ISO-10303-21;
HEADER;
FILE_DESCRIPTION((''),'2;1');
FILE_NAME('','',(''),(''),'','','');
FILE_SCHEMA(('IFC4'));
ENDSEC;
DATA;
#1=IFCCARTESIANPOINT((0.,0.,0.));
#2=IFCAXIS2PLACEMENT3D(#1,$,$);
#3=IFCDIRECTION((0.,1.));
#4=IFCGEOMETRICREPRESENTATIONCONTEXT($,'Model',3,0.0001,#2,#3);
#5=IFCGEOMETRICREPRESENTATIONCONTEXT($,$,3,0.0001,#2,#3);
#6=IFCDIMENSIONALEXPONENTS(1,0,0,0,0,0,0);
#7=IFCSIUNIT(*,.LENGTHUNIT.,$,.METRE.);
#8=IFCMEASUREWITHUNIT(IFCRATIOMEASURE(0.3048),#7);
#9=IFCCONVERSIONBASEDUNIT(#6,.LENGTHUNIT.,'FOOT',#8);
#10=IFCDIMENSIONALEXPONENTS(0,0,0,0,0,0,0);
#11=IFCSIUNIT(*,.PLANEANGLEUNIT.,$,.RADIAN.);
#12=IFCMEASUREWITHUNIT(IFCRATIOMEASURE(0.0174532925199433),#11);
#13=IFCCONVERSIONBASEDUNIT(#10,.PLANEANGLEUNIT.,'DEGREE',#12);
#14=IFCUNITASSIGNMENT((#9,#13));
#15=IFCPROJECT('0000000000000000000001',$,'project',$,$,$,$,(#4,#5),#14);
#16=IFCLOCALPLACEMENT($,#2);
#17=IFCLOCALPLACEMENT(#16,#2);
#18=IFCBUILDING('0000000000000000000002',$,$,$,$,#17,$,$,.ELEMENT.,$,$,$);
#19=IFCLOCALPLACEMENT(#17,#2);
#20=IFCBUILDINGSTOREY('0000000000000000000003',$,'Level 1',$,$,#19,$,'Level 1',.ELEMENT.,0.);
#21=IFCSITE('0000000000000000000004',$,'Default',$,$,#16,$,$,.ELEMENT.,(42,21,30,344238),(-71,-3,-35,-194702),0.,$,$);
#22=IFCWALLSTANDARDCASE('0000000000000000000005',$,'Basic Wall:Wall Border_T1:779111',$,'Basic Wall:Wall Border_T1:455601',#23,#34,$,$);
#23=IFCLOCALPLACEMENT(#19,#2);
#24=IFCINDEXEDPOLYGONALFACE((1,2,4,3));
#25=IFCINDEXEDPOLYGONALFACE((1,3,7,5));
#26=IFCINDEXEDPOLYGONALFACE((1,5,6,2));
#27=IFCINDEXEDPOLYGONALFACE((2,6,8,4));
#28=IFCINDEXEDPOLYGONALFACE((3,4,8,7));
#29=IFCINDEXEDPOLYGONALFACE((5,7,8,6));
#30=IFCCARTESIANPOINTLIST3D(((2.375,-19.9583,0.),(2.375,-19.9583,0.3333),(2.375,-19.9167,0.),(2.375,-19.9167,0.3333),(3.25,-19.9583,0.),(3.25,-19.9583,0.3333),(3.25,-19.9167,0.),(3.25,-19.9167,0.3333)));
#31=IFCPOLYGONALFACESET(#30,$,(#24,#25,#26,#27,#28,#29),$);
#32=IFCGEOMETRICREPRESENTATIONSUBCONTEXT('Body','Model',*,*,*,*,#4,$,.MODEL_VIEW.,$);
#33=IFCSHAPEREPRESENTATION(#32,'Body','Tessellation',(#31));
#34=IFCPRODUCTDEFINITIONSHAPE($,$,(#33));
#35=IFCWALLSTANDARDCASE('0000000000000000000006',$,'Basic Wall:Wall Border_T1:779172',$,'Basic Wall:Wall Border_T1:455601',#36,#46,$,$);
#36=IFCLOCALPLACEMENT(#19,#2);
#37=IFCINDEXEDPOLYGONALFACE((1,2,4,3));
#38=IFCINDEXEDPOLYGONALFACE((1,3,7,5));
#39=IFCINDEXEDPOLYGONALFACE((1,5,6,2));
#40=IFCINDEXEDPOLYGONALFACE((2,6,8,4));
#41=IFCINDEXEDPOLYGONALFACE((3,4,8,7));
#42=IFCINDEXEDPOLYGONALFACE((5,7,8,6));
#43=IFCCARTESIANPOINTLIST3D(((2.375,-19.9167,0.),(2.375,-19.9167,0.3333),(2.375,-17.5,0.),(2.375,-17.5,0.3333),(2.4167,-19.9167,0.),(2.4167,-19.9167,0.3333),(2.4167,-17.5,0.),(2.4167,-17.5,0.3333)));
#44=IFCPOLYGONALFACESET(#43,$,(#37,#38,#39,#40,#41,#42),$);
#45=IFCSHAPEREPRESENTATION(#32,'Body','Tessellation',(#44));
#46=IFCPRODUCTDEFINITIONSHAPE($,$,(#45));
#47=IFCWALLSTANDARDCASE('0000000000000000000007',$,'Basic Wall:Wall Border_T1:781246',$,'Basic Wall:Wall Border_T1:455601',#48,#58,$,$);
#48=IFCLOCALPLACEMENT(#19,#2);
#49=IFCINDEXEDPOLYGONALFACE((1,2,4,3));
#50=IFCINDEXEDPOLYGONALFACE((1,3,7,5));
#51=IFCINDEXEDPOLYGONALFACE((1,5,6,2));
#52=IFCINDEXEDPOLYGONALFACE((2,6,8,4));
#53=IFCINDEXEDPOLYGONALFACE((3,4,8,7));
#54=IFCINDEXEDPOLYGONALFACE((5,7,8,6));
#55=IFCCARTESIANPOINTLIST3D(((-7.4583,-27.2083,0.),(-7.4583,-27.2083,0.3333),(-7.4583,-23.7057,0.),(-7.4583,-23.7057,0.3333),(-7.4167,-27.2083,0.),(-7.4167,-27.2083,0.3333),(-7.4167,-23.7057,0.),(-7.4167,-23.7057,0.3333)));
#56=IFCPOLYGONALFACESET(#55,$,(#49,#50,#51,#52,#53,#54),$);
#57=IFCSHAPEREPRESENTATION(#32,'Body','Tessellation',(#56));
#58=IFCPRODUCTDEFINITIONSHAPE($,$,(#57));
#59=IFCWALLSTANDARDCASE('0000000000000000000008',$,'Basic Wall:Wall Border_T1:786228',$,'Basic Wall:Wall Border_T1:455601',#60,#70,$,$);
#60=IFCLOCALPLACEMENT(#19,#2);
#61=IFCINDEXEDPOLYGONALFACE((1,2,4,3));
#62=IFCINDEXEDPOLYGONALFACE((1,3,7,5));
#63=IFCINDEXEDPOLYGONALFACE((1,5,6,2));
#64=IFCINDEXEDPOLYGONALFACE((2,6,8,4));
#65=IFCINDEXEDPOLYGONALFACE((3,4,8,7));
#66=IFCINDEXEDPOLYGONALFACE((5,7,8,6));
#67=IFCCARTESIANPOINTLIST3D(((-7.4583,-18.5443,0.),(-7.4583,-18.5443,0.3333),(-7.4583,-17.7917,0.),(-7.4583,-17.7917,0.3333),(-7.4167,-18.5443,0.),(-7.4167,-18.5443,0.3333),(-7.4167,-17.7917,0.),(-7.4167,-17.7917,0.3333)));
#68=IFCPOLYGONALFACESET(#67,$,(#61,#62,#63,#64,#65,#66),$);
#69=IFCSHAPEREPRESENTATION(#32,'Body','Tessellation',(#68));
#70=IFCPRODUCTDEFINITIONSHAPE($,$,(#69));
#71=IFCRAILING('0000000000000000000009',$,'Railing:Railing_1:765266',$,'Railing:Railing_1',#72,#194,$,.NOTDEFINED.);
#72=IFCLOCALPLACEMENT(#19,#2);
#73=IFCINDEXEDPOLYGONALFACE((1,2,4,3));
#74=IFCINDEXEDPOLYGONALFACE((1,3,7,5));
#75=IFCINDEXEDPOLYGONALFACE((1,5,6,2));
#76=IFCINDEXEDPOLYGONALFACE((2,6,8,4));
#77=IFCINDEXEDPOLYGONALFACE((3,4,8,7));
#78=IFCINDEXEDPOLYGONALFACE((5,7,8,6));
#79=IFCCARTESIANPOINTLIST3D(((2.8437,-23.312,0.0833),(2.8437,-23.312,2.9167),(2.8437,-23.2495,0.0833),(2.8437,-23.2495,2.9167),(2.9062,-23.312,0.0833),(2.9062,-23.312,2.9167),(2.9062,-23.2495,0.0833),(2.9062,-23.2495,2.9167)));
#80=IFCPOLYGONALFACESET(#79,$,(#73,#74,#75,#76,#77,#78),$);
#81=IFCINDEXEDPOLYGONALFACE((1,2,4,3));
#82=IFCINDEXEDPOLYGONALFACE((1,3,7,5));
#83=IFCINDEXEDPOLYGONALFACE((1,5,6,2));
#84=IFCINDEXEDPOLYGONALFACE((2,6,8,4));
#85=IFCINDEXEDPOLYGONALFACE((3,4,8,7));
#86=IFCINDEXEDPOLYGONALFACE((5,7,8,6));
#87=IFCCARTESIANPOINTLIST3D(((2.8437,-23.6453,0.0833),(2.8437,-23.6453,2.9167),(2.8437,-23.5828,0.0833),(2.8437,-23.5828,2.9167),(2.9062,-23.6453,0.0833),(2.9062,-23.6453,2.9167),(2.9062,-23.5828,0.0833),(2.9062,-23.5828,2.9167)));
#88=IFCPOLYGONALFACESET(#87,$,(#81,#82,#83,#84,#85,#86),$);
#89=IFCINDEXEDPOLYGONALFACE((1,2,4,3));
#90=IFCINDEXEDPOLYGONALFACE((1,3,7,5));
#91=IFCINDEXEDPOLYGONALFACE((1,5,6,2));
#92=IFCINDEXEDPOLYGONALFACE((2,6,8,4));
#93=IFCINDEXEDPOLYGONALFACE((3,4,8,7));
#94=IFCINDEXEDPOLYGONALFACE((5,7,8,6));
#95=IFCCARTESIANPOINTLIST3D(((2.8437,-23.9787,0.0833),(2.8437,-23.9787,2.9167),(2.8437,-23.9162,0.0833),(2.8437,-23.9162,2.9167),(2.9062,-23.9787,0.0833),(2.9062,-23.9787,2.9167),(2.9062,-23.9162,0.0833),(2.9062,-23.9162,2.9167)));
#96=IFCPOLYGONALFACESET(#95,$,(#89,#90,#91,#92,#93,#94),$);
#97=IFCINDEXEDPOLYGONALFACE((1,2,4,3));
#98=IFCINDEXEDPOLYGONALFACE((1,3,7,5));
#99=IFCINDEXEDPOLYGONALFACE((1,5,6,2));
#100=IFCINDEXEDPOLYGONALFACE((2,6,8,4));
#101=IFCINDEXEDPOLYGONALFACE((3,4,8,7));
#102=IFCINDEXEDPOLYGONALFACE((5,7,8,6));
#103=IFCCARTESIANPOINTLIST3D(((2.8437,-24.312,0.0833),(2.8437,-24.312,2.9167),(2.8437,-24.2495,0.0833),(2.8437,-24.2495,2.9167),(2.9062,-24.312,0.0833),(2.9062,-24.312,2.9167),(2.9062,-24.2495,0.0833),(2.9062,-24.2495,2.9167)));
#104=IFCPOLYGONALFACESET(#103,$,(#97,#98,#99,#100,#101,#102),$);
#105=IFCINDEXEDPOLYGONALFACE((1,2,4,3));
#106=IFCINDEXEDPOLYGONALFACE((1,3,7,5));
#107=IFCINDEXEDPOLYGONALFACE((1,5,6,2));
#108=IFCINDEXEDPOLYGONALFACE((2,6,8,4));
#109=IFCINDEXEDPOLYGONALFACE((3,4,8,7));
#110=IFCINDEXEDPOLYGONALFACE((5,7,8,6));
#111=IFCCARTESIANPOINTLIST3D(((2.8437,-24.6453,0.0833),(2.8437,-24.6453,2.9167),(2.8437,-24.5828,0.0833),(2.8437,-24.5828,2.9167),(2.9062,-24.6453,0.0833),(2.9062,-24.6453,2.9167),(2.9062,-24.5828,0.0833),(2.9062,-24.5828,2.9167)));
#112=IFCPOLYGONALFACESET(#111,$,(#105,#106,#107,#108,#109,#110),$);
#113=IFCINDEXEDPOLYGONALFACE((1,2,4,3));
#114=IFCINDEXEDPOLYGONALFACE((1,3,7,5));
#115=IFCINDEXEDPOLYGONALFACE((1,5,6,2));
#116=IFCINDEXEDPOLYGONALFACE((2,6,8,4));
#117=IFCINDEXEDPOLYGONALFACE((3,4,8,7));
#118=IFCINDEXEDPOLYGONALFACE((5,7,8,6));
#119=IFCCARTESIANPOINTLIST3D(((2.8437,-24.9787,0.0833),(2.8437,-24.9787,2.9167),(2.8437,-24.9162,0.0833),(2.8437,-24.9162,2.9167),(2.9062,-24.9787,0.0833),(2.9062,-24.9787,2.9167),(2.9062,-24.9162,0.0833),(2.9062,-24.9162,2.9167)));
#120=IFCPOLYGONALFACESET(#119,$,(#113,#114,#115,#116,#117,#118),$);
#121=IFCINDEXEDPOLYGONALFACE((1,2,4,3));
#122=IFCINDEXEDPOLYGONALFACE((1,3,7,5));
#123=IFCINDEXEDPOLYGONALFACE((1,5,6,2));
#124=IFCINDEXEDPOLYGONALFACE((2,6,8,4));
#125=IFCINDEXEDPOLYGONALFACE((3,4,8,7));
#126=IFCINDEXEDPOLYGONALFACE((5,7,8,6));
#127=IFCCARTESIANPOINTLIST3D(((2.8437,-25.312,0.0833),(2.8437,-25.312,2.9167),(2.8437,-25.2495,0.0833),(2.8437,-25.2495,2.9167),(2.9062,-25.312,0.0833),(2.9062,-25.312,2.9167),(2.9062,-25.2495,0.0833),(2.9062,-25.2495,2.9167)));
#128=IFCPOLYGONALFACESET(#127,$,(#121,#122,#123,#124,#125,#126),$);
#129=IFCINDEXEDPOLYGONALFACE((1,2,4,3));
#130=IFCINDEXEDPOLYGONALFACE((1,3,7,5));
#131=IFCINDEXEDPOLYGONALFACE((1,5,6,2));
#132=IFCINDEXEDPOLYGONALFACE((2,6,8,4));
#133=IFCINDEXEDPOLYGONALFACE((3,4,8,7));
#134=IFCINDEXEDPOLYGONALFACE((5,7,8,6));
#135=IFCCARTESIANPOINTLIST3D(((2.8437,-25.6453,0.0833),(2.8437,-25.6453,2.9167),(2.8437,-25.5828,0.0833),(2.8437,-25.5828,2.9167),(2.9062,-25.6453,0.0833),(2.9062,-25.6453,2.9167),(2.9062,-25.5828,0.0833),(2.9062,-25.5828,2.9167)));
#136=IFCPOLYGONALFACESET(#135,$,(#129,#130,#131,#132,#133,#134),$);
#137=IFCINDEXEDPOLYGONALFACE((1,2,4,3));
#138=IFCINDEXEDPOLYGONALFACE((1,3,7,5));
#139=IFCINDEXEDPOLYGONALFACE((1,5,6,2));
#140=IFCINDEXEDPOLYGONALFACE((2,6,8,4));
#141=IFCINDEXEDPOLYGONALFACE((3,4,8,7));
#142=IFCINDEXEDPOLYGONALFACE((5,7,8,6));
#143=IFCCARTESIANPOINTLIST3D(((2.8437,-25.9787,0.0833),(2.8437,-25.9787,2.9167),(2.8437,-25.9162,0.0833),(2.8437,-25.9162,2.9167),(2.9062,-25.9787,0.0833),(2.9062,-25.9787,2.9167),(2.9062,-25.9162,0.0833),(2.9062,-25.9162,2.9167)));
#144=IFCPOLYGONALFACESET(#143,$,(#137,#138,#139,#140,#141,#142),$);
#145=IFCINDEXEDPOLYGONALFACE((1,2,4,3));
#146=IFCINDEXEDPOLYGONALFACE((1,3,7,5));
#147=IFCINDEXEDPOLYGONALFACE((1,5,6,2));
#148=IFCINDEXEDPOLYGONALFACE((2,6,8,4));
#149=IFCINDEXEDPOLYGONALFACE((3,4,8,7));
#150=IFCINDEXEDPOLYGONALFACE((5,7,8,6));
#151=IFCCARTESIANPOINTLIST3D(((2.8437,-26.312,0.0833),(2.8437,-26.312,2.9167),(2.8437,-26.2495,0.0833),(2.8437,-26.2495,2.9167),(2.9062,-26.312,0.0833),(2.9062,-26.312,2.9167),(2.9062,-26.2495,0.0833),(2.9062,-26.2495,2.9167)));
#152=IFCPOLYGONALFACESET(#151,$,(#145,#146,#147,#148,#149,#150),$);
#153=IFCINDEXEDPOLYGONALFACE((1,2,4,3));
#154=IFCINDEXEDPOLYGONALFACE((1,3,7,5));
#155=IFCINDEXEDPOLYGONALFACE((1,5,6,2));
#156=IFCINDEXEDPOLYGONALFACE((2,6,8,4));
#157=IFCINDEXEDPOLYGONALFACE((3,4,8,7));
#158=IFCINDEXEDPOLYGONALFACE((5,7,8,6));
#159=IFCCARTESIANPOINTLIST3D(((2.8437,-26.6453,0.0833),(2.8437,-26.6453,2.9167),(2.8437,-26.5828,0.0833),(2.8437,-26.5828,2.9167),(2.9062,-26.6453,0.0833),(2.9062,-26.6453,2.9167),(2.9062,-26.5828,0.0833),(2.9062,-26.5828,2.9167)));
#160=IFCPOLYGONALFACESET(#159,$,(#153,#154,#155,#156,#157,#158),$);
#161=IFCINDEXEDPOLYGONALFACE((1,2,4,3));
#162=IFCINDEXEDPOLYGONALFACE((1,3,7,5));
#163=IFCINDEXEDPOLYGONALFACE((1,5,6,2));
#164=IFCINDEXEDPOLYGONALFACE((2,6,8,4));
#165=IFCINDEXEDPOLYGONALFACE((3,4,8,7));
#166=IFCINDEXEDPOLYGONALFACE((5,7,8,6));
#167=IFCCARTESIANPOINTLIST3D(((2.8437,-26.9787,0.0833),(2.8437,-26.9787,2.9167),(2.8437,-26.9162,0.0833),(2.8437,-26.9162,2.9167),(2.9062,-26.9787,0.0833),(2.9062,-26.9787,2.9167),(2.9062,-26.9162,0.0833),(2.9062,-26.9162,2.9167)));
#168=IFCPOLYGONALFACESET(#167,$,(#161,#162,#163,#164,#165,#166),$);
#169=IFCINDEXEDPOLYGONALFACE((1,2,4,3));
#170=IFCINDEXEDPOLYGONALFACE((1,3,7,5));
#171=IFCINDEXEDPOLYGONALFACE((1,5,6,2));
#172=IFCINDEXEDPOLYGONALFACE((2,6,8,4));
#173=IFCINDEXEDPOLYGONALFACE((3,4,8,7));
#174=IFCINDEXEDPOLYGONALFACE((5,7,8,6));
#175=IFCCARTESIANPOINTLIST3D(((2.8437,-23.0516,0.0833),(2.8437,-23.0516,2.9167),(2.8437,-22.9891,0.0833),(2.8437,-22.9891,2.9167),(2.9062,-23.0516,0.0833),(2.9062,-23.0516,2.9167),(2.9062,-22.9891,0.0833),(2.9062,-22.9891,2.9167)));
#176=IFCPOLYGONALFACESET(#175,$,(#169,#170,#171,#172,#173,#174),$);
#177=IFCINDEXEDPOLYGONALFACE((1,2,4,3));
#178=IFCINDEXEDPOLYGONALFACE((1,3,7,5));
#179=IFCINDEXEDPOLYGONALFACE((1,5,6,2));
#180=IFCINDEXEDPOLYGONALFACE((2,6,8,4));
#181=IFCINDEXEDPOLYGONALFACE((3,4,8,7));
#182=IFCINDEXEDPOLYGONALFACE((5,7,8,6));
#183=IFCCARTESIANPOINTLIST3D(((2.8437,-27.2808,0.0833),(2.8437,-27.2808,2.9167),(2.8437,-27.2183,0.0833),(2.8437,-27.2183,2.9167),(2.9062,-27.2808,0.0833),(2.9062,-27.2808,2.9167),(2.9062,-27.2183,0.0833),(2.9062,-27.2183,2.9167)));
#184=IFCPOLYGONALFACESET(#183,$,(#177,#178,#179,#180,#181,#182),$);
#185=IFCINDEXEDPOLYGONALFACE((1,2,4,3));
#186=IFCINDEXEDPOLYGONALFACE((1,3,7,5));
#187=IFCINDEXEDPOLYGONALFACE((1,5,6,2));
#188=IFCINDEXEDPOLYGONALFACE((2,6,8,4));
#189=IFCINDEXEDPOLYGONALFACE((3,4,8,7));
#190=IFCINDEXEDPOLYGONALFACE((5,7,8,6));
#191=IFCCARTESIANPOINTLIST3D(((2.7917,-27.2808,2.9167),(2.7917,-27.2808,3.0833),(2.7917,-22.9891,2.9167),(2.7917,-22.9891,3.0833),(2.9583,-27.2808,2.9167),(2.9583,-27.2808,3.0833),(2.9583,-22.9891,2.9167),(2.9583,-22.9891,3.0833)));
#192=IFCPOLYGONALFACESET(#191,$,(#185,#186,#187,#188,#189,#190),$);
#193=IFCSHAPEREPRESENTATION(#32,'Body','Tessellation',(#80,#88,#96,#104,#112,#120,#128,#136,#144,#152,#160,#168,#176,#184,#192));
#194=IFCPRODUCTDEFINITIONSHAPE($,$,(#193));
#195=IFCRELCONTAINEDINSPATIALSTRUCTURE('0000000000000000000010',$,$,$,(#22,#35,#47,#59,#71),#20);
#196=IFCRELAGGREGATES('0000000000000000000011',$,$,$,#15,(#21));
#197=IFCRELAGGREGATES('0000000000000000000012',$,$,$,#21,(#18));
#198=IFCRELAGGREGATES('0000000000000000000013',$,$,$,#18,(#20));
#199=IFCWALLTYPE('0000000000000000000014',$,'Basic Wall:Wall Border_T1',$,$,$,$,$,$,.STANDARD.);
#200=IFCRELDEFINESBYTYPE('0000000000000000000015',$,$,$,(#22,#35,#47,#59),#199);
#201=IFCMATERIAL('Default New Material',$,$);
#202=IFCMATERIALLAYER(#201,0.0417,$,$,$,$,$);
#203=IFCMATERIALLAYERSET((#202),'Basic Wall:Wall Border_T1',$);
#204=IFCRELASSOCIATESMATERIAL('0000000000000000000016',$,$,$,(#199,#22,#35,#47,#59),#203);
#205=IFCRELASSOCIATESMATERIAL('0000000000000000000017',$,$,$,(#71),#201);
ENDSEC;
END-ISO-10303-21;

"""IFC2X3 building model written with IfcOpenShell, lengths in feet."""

from ifc_helpers import new_model, entity, si_unit, converted_unit, direction, frame, frame_2d, origin, origin_2d_with_axis, place, context, subcontext, project, spatial, rectangle, extrude, material, layer, layer_set, layer_usage, type_object, element, save


model = new_model("IFC2X3")

# Units and contexts
model_context = context("Model", 3, precision=0.0001, world=origin(), true_north=direction((0.0, 1.0)))
context_of_model = context(None, 3, precision=0.0001, world=origin(), true_north=direction((0.0, 1.0)))
body_context = subcontext(model_context, "Body", "Model", "MODEL_VIEW")
ifc_project = project(units=[converted_unit("LENGTHUNIT", "FOOT", entity("IfcRatioMeasure", 0.3048), si_unit("LENGTHUNIT", "METRE"), dimensions=[1, 0, 0, 0, 0, 0, 0]), converted_unit("PLANEANGLEUNIT", "DEGREE", entity("IfcRatioMeasure", 0.0174532925199433), si_unit("PLANEANGLEUNIT", "RADIAN"), dimensions=[0, 0, 0, 0, 0, 0, 0])], contexts=[model_context, context_of_model])

# Site, building, storey
site_placement = place(None, origin())
site = spatial("IfcSite", under=ifc_project, at=site_placement, Name="Default", CompositionType="ELEMENT", RefLatitude=(42, 21, 30, 344238), RefLongitude=(-71, -3, -35, -194702), RefElevation=0.0)
building_placement = place(site_placement, origin())
building = spatial("IfcBuilding", under=site, at=building_placement, CompositionType="ELEMENT")
storey_placement = place(building_placement, origin())
storey = spatial("IfcBuildingStorey", under=building, at=storey_placement, Name="Level 1", LongName="Level 1", CompositionType="ELEMENT", Elevation=0.0)

# Shared definitions
ifc_material = material(Name="Default New Material")

# Walls
ifc_layer_1 = layer(ifc_material, 0.0417)
ifc_layer_set_1 = layer_set([ifc_layer_1], Name="Basic Wall:Wall Border_T1")
wall_type_1 = type_object("IfcWallType", Name="Basic Wall:Wall Border_T1", PredefinedType="STANDARD", material=ifc_layer_set_1)
ifc_layer_usage_1 = layer_usage(ifc_layer_set_1, "AXIS2", "NEGATIVE", 0.0208)
wall_1_placement = place(storey_placement, frame((3.25, -19.9375, 0.0), z_axis=(0.0, 0.0, 1.0), x_axis=(-1.0, 0.0, 0.0)))
element("IfcWallStandardCase", 1, at=wall_1_placement, inside=storey, type_object=wall_type_1, material=ifc_layer_usage_1, Name="Basic Wall:Wall Border_T1:779111", ObjectType="Basic Wall:Wall Border_T1:455601", context=body_context, shape_type="SweptSolid", body=[
    extrude(rectangle(XDim=0.875, YDim=0.0417, at=frame_2d((0.4375, 0.0), x_axis=(-1.0, 0.0))), origin(), (0.0, 0.0, 1.0), 0.3333),
])
ifc_layer_usage_2 = layer_usage(ifc_layer_set_1, "AXIS2", "NEGATIVE", 0.0208)
wall_2_placement = place(storey_placement, frame((2.3958, -19.9167, 0.0), z_axis=(0.0, 0.0, 1.0), x_axis=(0.0, 1.0, 0.0)))
element("IfcWallStandardCase", 2, at=wall_2_placement, inside=storey, type_object=wall_type_1, material=ifc_layer_usage_2, Name="Basic Wall:Wall Border_T1:779172", ObjectType="Basic Wall:Wall Border_T1:455601", context=body_context, shape_type="SweptSolid", body=[
    extrude(rectangle(XDim=2.4167, YDim=0.0417, at=frame_2d((1.2083, 0.0), x_axis=(-1.0, 0.0))), origin(), (0.0, 0.0, 1.0), 0.3333),
])
ifc_layer_usage_3 = layer_usage(ifc_layer_set_1, "AXIS2", "POSITIVE", -0.0208)
wall_3_placement = place(storey_placement, frame((-7.4375, -27.2083, 0.0), z_axis=(0.0, 0.0, 1.0), x_axis=(0.0, 1.0, 0.0)))
element("IfcWallStandardCase", 3, at=wall_3_placement, inside=storey, type_object=wall_type_1, material=ifc_layer_usage_3, Name="Basic Wall:Wall Border_T1:781246", ObjectType="Basic Wall:Wall Border_T1:455601", context=body_context, shape_type="SweptSolid", body=[
    extrude(rectangle(XDim=3.5026, YDim=0.0417, at=frame_2d((1.7513, 0.0), x_axis=(-1.0, 0.0))), origin(), (0.0, 0.0, 1.0), 0.3333),
])
ifc_layer_usage_4 = layer_usage(ifc_layer_set_1, "AXIS2", "POSITIVE", -0.0208)
wall_4_placement = place(storey_placement, frame((-7.4375, -18.5443, 0.0), z_axis=(0.0, 0.0, 1.0), x_axis=(0.0, 1.0, 0.0)))
element("IfcWallStandardCase", 4, at=wall_4_placement, inside=storey, type_object=wall_type_1, material=ifc_layer_usage_4, Name="Basic Wall:Wall Border_T1:786228", ObjectType="Basic Wall:Wall Border_T1:455601", context=body_context, shape_type="SweptSolid", body=[
    extrude(rectangle(XDim=0.7526, YDim=0.0417, at=frame_2d((0.3763, 0.0), x_axis=(-1.0, 0.0))), origin(), (0.0, 0.0, 1.0), 0.3333),
])

# Railing
railing_placement = place(storey_placement, frame((2.7917, -27.2808, 0.0833)))
element("IfcRailing", 5, at=railing_placement, inside=storey, material=ifc_material, Name="Railing:Railing_1:765266", ObjectType="Railing:Railing_1", PredefinedType="NOTDEFINED", context=body_context, shape_type="SweptSolid", body=[
    extrude(rectangle(XDim=0.0625, YDim=0.0625, at=origin_2d_with_axis()), frame((0.0833, 4.0, 0.0), z_axis=(0.0, 0.0, 1.0), x_axis=(0.0, 1.0, 0.0)), (0.0, 0.0, 1.0), 2.8333),
    extrude(rectangle(XDim=0.0625, YDim=0.0625, at=origin_2d_with_axis()), frame((0.0833, 3.6667, 0.0), z_axis=(0.0, 0.0, 1.0), x_axis=(0.0, 1.0, 0.0)), (0.0, 0.0, 1.0), 2.8333),
    extrude(rectangle(XDim=0.0625, YDim=0.0625, at=origin_2d_with_axis()), frame((0.0833, 3.3333, 0.0), z_axis=(0.0, 0.0, 1.0), x_axis=(0.0, 1.0, 0.0)), (0.0, 0.0, 1.0), 2.8333),
    extrude(rectangle(XDim=0.0625, YDim=0.0625, at=origin_2d_with_axis()), frame((0.0833, 3.0, 0.0), z_axis=(0.0, 0.0, 1.0), x_axis=(0.0, 1.0, 0.0)), (0.0, 0.0, 1.0), 2.8333),
    extrude(rectangle(XDim=0.0625, YDim=0.0625, at=origin_2d_with_axis()), frame((0.0833, 2.6667, 0.0), z_axis=(0.0, 0.0, 1.0), x_axis=(0.0, 1.0, 0.0)), (0.0, 0.0, 1.0), 2.8333),
    extrude(rectangle(XDim=0.0625, YDim=0.0625, at=origin_2d_with_axis()), frame((0.0833, 2.3333, 0.0), z_axis=(0.0, 0.0, 1.0), x_axis=(0.0, 1.0, 0.0)), (0.0, 0.0, 1.0), 2.8333),
    extrude(rectangle(XDim=0.0625, YDim=0.0625, at=origin_2d_with_axis()), frame((0.0833, 2.0, 0.0), z_axis=(0.0, 0.0, 1.0), x_axis=(0.0, 1.0, 0.0)), (0.0, 0.0, 1.0), 2.8333),
    extrude(rectangle(XDim=0.0625, YDim=0.0625, at=origin_2d_with_axis()), frame((0.0833, 1.6667, 0.0), z_axis=(0.0, 0.0, 1.0), x_axis=(0.0, 1.0, 0.0)), (0.0, 0.0, 1.0), 2.8333),
    extrude(rectangle(XDim=0.0625, YDim=0.0625, at=origin_2d_with_axis()), frame((0.0833, 1.3333, 0.0), z_axis=(0.0, 0.0, 1.0), x_axis=(0.0, 1.0, 0.0)), (0.0, 0.0, 1.0), 2.8333),
    extrude(rectangle(XDim=0.0625, YDim=0.0625, at=origin_2d_with_axis()), frame((0.0833, 1.0, 0.0), z_axis=(0.0, 0.0, 1.0), x_axis=(0.0, 1.0, 0.0)), (0.0, 0.0, 1.0), 2.8333),
    extrude(rectangle(XDim=0.0625, YDim=0.0625, at=origin_2d_with_axis()), frame((0.0833, 0.6667, 0.0), z_axis=(0.0, 0.0, 1.0), x_axis=(0.0, 1.0, 0.0)), (0.0, 0.0, 1.0), 2.8333),
    extrude(rectangle(XDim=0.0625, YDim=0.0625, at=origin_2d_with_axis()), frame((0.0833, 0.3333, 0.0), z_axis=(0.0, 0.0, 1.0), x_axis=(0.0, 1.0, 0.0)), (0.0, 0.0, 1.0), 2.8333),
    extrude(rectangle(XDim=0.0625, YDim=0.0625, at=origin_2d_with_axis()), frame((0.0833, 4.2604, 0.0), z_axis=(0.0, 0.0, 1.0), x_axis=(0.0, 1.0, 0.0)), (0.0, 0.0, 1.0), 2.8333),
    extrude(rectangle(XDim=0.0625, YDim=0.0625, at=origin_2d_with_axis()), frame((0.0833, 0.0313, 0.0), z_axis=(0.0, 0.0, 1.0), x_axis=(0.0, 1.0, 0.0)), (0.0, 0.0, 1.0), 2.8333),
    extrude(rectangle(XDim=4.2917, YDim=0.1667, at=frame_2d((0.0, 0.0), x_axis=(1.0, 0.0))), frame((0.0833, 2.1458, 2.8333), z_axis=(0.0, 0.0, 1.0), x_axis=(0.0, 1.0, 0.0)), (0.0, 0.0, 1.0), 0.1667),
])

save(model, "model.ifc")
